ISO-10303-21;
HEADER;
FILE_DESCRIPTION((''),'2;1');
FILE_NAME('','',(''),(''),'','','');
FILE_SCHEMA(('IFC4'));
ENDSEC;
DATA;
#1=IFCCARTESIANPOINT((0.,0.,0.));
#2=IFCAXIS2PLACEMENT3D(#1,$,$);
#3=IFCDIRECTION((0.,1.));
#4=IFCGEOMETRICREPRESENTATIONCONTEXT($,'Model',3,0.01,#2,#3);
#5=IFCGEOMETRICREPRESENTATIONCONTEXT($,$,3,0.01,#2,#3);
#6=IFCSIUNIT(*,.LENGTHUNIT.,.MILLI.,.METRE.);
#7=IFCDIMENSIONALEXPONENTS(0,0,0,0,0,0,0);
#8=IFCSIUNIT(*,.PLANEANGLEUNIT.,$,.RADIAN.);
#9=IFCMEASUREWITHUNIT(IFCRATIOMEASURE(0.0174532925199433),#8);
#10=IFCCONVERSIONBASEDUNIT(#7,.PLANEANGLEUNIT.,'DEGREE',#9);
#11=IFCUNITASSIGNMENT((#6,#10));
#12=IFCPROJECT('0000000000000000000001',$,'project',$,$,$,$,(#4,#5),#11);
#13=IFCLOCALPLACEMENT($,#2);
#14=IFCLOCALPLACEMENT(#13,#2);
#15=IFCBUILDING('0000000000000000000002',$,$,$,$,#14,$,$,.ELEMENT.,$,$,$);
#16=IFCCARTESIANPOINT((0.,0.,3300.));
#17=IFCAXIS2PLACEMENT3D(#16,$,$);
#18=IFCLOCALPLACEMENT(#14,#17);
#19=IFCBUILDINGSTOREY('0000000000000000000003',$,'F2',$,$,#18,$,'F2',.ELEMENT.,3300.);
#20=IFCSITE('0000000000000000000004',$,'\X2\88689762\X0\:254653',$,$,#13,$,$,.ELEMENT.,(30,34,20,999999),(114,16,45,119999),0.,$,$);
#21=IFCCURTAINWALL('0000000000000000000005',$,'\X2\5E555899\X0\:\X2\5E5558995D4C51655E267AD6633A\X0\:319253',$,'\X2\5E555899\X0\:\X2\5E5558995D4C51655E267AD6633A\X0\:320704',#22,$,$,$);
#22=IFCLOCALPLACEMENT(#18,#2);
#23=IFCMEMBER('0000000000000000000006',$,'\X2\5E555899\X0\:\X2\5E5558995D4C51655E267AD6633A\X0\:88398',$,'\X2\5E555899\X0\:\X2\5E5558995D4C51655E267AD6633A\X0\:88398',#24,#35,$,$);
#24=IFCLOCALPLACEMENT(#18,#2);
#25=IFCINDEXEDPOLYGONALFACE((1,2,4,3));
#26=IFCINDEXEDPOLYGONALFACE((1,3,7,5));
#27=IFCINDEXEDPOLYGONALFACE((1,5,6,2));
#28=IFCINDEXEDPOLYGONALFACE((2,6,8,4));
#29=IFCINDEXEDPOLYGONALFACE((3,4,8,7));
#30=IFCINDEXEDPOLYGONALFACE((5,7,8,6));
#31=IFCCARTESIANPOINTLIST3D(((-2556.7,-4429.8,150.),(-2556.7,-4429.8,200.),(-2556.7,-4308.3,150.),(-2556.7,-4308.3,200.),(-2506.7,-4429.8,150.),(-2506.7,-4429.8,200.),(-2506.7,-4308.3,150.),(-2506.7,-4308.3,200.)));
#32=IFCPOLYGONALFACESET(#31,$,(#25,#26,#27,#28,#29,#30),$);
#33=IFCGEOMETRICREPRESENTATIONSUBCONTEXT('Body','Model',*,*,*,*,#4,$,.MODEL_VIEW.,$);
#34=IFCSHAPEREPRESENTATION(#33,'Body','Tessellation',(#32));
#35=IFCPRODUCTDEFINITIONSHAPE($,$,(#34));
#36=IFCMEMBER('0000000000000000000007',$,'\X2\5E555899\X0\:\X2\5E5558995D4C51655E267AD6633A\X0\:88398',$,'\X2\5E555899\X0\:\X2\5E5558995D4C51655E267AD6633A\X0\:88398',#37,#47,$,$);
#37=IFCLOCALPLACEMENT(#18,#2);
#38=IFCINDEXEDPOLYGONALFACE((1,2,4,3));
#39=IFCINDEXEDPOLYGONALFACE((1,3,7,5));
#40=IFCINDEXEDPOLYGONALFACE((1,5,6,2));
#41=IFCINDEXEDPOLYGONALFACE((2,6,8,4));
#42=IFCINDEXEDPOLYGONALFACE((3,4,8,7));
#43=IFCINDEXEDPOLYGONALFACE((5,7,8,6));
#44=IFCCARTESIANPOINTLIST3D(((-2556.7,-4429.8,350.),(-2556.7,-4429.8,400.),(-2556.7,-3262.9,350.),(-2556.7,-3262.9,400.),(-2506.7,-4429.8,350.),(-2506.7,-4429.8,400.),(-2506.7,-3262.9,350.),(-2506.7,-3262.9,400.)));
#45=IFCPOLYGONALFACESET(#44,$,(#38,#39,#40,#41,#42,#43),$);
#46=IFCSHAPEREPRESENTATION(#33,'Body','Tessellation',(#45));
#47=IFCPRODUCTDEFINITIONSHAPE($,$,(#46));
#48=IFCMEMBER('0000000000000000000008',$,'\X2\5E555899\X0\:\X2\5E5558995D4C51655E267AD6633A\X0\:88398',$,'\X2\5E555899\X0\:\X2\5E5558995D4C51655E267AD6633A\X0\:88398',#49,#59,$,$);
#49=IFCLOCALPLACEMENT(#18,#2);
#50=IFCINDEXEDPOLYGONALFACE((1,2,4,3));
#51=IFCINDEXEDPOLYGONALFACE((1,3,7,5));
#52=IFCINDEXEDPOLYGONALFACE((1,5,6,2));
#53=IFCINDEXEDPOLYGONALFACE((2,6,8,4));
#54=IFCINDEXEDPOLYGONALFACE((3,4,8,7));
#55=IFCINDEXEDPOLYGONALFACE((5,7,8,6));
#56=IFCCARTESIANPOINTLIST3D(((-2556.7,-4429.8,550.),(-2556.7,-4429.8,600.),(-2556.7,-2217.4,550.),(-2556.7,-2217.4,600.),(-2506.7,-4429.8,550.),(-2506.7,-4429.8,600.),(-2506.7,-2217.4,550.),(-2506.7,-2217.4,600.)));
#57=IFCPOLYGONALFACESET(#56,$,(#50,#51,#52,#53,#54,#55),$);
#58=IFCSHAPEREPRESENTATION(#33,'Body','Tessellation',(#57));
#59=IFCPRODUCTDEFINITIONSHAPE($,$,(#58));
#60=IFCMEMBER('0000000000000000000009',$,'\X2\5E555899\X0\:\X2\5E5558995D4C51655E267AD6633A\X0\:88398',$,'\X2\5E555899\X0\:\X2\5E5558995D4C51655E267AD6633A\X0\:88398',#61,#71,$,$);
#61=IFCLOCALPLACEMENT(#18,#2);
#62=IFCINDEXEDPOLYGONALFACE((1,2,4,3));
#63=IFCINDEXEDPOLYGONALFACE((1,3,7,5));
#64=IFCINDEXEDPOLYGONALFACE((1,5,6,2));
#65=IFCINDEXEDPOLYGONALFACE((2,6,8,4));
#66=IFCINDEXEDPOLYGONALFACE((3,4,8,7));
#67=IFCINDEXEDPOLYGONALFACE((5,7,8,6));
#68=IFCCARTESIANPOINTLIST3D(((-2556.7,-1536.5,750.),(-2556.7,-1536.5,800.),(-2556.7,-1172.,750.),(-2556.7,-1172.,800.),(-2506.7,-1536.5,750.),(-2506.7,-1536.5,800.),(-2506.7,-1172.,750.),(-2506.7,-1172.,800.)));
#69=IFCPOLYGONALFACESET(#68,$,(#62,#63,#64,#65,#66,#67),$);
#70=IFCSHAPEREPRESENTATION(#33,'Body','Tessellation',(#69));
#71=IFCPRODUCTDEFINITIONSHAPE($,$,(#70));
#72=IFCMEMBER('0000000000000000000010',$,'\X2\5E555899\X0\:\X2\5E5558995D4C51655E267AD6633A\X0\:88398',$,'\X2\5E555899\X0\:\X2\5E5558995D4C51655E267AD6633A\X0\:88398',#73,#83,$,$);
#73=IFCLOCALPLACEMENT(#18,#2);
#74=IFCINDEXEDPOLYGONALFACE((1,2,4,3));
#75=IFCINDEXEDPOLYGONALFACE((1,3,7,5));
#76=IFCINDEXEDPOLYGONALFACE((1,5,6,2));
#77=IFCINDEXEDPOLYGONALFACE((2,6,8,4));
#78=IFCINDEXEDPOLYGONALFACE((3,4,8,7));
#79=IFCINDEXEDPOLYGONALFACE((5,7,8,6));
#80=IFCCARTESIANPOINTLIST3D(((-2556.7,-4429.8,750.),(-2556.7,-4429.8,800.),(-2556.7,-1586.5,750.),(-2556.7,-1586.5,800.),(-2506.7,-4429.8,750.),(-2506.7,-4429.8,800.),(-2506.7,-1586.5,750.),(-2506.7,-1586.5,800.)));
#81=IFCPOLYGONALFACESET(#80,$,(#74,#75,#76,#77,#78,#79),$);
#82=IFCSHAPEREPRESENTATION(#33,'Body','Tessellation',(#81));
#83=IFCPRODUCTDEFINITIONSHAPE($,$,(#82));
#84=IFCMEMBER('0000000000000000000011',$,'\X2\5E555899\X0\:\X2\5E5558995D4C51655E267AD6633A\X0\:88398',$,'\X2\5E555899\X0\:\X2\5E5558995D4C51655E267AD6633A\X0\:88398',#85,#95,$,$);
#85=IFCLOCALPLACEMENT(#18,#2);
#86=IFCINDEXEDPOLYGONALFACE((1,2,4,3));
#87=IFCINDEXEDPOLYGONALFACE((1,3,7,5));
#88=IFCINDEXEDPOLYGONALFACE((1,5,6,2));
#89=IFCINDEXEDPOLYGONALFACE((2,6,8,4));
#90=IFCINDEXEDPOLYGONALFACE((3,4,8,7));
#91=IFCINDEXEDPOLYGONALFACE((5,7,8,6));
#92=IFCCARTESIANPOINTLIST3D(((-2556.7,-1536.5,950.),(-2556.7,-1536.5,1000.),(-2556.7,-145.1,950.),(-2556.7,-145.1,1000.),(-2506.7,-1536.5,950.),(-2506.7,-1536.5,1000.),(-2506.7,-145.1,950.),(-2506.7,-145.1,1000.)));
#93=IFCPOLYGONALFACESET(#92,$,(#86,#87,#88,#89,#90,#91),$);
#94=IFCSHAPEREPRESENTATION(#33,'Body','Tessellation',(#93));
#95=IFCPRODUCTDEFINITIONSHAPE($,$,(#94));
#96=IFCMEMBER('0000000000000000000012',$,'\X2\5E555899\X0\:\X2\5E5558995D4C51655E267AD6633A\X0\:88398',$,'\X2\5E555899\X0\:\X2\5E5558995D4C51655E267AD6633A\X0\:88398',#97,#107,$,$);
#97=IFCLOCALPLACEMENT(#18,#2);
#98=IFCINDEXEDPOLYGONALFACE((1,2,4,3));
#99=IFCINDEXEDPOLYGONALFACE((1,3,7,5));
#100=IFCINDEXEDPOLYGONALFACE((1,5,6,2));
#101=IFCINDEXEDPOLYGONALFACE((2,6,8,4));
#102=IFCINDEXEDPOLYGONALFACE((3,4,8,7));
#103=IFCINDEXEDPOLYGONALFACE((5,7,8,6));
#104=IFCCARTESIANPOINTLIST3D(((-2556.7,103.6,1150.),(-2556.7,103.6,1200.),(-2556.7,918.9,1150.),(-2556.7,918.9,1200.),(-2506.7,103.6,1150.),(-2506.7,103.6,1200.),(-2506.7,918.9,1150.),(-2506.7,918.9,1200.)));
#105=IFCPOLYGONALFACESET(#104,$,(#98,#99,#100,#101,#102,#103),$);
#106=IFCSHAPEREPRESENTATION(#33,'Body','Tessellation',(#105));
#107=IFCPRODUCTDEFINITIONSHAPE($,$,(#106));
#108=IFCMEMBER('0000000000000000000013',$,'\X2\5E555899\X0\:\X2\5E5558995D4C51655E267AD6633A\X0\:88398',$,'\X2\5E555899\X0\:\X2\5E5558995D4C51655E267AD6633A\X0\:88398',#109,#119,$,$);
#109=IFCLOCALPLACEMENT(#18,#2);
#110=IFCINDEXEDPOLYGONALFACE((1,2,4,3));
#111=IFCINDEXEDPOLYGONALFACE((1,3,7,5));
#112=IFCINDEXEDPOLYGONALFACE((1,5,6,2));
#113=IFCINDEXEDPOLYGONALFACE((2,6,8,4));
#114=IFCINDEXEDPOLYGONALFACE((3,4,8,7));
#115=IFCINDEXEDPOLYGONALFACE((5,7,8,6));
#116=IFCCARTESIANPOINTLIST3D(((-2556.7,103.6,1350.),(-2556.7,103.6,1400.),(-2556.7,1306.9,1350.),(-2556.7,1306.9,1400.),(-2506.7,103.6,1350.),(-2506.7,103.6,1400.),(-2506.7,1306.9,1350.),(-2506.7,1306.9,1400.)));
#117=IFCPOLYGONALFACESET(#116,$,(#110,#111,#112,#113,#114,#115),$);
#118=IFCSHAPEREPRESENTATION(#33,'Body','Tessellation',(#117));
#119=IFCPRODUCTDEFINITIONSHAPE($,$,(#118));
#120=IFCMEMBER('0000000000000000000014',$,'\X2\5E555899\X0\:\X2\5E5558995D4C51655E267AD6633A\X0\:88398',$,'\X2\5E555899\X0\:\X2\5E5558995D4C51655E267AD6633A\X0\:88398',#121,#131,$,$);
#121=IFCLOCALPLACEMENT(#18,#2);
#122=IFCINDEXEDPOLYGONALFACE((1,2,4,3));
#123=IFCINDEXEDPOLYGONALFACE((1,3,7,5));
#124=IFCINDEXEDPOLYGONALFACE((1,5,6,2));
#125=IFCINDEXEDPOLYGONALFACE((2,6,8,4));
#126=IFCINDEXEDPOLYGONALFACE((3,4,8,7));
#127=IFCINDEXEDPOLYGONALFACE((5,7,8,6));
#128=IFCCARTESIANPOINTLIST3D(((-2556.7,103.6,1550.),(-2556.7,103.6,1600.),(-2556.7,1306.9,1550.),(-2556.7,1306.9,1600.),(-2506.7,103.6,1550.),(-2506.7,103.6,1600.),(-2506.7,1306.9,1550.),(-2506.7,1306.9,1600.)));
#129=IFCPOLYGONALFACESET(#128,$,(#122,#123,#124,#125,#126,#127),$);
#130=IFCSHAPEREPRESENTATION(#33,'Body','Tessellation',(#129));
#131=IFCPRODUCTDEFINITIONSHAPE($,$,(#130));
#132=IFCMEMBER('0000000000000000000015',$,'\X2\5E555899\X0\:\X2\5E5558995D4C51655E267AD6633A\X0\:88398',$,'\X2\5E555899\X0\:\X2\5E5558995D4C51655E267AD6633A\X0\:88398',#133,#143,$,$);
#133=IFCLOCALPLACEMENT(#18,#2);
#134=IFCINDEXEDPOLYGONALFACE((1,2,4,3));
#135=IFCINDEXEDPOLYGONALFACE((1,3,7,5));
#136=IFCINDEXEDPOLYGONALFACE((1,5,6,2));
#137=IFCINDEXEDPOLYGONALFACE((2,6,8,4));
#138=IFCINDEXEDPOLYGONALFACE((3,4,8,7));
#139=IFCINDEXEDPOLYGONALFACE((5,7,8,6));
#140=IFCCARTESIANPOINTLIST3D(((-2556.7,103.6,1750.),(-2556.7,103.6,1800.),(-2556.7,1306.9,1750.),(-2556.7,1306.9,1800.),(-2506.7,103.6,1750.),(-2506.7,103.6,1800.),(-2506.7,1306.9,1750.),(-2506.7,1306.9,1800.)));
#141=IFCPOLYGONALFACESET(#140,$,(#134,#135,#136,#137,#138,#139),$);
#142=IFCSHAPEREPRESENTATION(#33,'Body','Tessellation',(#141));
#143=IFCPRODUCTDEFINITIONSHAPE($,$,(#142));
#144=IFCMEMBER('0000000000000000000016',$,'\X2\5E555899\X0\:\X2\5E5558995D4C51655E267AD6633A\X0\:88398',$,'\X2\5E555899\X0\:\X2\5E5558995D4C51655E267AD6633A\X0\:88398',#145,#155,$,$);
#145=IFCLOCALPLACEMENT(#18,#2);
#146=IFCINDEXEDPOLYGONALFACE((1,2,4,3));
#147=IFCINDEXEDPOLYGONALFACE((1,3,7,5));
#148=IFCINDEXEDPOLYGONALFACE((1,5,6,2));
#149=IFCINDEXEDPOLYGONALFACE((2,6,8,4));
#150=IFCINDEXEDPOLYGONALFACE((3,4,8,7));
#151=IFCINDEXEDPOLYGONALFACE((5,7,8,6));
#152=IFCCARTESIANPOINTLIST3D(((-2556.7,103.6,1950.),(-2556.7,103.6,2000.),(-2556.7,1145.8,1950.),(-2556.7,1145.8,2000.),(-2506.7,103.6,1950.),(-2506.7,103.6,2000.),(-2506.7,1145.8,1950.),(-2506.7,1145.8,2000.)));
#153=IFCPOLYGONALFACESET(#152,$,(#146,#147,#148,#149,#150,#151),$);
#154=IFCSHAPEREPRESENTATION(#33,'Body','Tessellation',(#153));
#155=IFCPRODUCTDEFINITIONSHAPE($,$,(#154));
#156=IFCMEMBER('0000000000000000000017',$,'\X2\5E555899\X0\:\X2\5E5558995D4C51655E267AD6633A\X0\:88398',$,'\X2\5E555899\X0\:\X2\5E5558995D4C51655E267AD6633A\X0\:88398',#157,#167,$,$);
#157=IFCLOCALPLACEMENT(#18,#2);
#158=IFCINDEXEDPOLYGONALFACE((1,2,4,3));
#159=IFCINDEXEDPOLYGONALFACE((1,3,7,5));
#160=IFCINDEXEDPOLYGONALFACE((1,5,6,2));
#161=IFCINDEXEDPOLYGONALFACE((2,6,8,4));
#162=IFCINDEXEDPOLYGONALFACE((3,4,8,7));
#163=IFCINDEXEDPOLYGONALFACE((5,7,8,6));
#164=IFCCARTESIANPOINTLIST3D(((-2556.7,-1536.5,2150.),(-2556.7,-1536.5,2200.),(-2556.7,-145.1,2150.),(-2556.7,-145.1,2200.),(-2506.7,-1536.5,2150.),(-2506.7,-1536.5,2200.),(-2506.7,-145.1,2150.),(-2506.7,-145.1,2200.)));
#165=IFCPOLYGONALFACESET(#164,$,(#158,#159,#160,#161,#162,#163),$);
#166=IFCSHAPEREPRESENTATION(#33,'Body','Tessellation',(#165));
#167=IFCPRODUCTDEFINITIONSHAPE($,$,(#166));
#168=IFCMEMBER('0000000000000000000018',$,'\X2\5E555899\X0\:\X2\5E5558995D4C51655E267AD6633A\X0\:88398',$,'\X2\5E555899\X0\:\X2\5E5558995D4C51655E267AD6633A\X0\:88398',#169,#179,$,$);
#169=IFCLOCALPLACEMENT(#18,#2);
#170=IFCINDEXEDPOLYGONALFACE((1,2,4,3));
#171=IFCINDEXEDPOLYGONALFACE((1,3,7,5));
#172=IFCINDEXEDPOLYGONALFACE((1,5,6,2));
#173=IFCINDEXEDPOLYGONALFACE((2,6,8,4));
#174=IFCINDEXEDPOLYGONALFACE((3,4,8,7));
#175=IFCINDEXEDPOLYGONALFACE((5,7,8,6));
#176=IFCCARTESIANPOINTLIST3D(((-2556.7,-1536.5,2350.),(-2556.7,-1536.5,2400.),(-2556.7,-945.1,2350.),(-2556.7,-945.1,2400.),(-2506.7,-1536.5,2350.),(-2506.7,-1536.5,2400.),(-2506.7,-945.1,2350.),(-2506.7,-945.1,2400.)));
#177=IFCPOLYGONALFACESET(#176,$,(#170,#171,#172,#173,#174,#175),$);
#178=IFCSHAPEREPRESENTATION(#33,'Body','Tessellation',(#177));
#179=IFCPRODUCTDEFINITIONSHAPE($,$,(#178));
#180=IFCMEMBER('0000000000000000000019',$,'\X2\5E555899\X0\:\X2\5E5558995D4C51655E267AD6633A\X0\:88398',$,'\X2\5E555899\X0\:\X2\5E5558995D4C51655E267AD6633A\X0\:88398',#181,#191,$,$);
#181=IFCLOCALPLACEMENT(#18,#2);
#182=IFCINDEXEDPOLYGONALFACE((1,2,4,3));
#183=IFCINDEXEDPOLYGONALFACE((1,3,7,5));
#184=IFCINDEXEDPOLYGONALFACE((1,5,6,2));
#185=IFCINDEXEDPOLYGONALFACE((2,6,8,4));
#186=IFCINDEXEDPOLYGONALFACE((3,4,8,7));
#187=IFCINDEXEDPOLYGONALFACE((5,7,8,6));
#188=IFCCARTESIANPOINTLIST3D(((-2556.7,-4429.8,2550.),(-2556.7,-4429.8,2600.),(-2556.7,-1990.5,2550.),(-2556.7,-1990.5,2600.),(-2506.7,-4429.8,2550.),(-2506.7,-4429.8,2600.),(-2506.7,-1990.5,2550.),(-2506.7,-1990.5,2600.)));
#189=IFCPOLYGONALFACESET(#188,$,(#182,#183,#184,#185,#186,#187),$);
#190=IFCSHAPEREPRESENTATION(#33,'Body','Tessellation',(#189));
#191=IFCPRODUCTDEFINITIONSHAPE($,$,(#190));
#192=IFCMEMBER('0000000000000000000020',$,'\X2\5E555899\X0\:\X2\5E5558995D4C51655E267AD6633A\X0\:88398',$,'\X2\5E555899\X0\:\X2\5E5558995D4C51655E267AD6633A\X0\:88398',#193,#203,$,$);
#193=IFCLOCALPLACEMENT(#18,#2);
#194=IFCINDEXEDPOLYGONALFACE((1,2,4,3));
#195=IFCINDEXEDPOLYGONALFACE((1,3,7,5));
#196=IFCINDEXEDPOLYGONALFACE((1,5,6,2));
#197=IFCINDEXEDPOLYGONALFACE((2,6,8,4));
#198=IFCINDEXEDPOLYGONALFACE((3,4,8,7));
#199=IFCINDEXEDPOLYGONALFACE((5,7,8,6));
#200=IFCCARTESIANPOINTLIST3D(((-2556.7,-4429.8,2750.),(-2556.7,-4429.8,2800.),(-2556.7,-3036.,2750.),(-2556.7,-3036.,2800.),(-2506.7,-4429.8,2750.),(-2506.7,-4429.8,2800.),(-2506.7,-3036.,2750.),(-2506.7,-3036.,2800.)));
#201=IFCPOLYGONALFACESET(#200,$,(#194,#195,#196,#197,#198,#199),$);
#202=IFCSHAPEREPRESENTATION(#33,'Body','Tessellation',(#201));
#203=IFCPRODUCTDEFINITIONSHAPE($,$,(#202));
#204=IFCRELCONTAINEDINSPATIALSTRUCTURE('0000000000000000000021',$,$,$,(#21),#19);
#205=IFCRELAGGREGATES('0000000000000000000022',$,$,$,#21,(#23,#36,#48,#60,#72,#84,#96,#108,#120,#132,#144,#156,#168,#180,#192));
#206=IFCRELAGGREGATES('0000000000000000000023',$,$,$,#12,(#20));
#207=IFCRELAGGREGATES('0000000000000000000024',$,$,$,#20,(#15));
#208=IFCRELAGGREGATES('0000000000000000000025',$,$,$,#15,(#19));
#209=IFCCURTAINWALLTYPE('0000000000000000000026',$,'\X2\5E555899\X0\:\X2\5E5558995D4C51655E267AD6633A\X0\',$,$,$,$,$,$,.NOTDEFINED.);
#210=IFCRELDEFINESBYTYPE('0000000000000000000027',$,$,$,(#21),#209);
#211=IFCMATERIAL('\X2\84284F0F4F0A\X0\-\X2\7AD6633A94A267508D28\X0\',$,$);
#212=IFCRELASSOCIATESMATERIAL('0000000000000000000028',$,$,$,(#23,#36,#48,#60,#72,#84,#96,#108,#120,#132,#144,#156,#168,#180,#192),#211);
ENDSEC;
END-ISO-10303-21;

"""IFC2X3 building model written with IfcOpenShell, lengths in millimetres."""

from ifc_helpers import new_model, entity, si_unit, converted_unit, direction, frame, frame_2d, origin, origin_2d_with_axis, place, context, subcontext, project, spatial, rectangle, extrude, material, type_object, element, aggregate, save


model = new_model("IFC2X3")

# Units and contexts
model_context = context("Model", 3, precision=0.01, world=origin(), true_north=direction((0.0, 1.0)))
context_of_model = context(None, 3, precision=0.01, world=origin(), true_north=direction((0.0, 1.0)))
body_context = subcontext(model_context, "Body", "Model", "MODEL_VIEW")
ifc_project = project(units=[si_unit("LENGTHUNIT", "METRE", prefix="MILLI"), converted_unit("PLANEANGLEUNIT", "DEGREE", entity("IfcRatioMeasure", 0.0174532925199433), si_unit("PLANEANGLEUNIT", "RADIAN"), dimensions=[0, 0, 0, 0, 0, 0, 0])], contexts=[model_context, context_of_model])

# Site, building, storey
site_placement = place(None, origin())
site = spatial("IfcSite", under=ifc_project, at=site_placement, Name="表面:254653", CompositionType="ELEMENT", RefLatitude=(30, 34, 20, 999999), RefLongitude=(114, 16, 45, 119999), RefElevation=0.0)
building_placement = place(site_placement, origin())
building = spatial("IfcBuilding", under=site, at=building_placement, CompositionType="ELEMENT")
storey_placement = place(building_placement, frame((0.0, 0.0, 3300.0)))
storey = spatial("IfcBuildingStorey", under=building, at=storey_placement, Name="F2", LongName="F2", CompositionType="ELEMENT", Elevation=3300.0)

# Curtain wall, members
curtain_wall_type = type_object("IfcCurtainWallType", Name="幕墙:幕墙嵌入带竖挺", PredefinedType="NOTDEFINED")
curtain_wall_placement = place(storey_placement, frame((0.0, 0.0, -3300.0)))
curtain_wall = element("IfcCurtainWall", 1, at=curtain_wall_placement, inside=storey, type_object=curtain_wall_type, Name="幕墙:幕墙嵌入带竖挺:319253", ObjectType="幕墙:幕墙嵌入带竖挺:320704")
ifc_material = material(Name="萨伏伊-竖挺钢材质")
member_1_placement = place(curtain_wall_placement, frame((0.0, 0.0, 3300.0)))
member_1 = element("IfcMember", 2, at=member_1_placement, material=ifc_material, Name="幕墙:幕墙嵌入带竖挺:88398", ObjectType="幕墙:幕墙嵌入带竖挺:88398", context=body_context, shape_type="SweptSolid", body=[
    extrude(rectangle(XDim=50.0, YDim=50.0, at=frame_2d((0.0, 0.0), x_axis=(1.0, 0.0))), frame((-2531.7, -4429.8, 175.0), z_axis=(0.0, 1.0, 0.0), x_axis=(0.0, 0.0, -1.0)), (0.0, 0.0, 1.0), 121.5),
])
member_2_placement = place(curtain_wall_placement, frame((0.0, 0.0, 3300.0)))
member_2 = element("IfcMember", 3, at=member_2_placement, material=ifc_material, Name="幕墙:幕墙嵌入带竖挺:88398", ObjectType="幕墙:幕墙嵌入带竖挺:88398", context=body_context, shape_type="SweptSolid", body=[
    extrude(rectangle(XDim=50.0, YDim=50.0, at=origin_2d_with_axis()), frame((-2531.7, -4429.8, 375.0), z_axis=(0.0, 1.0, 0.0), x_axis=(0.0, 0.0, -1.0)), (0.0, 0.0, 1.0), 1166.9),
])
member_3_placement = place(curtain_wall_placement, frame((0.0, 0.0, 3300.0)))
member_3 = element("IfcMember", 4, at=member_3_placement, material=ifc_material, Name="幕墙:幕墙嵌入带竖挺:88398", ObjectType="幕墙:幕墙嵌入带竖挺:88398", context=body_context, shape_type="SweptSolid", body=[
    extrude(rectangle(XDim=50.0, YDim=50.0, at=frame_2d((0.0, 0.0), x_axis=(1.0, 0.0))), frame((-2531.7, -4429.8, 575.0), z_axis=(0.0, 1.0, 0.0), x_axis=(0.0, 0.0, -1.0)), (0.0, 0.0, 1.0), 2212.4),
])
member_4_placement = place(curtain_wall_placement, frame((0.0, 0.0, 3300.0)))
member_4 = element("IfcMember", 5, at=member_4_placement, material=ifc_material, Name="幕墙:幕墙嵌入带竖挺:88398", ObjectType="幕墙:幕墙嵌入带竖挺:88398", context=body_context, shape_type="SweptSolid", body=[
    extrude(rectangle(XDim=50.0, YDim=50.0, at=frame_2d((0.0, 0.0), x_axis=(1.0, 0.0))), frame((-2531.7, -1536.5, 775.0), z_axis=(0.0, 1.0, 0.0), x_axis=(0.0, 0.0, -1.0)), (0.0, 0.0, 1.0), 364.5),
])
member_5_placement = place(curtain_wall_placement, frame((0.0, 0.0, 3300.0)))
member_5 = element("IfcMember", 6, at=member_5_placement, material=ifc_material, Name="幕墙:幕墙嵌入带竖挺:88398", ObjectType="幕墙:幕墙嵌入带竖挺:88398", context=body_context, shape_type="SweptSolid", body=[
    extrude(rectangle(XDim=50.0, YDim=50.0, at=origin_2d_with_axis()), frame((-2531.7, -4429.8, 775.0), z_axis=(0.0, 1.0, 0.0), x_axis=(0.0, 0.0, -1.0)), (0.0, 0.0, 1.0), 2843.3),
])
member_6_placement = place(curtain_wall_placement, frame((0.0, 0.0, 3300.0)))
member_6 = element("IfcMember", 7, at=member_6_placement, material=ifc_material, Name="幕墙:幕墙嵌入带竖挺:88398", ObjectType="幕墙:幕墙嵌入带竖挺:88398", context=body_context, shape_type="SweptSolid", body=[
    extrude(rectangle(XDim=50.0, YDim=50.0, at=frame_2d((0.0, 0.0), x_axis=(1.0, 0.0))), frame((-2531.7, -1536.5, 975.0), z_axis=(0.0, 1.0, 0.0), x_axis=(0.0, 0.0, -1.0)), (0.0, 0.0, 1.0), 1391.3),
])
member_7_placement = place(curtain_wall_placement, frame((0.0, 0.0, 3300.0)))
member_7 = element("IfcMember", 8, at=member_7_placement, material=ifc_material, Name="幕墙:幕墙嵌入带竖挺:88398", ObjectType="幕墙:幕墙嵌入带竖挺:88398", context=body_context, shape_type="SweptSolid", body=[
    extrude(rectangle(XDim=50.0, YDim=50.0, at=origin_2d_with_axis()), frame((-2531.7, 103.6, 1175.0), z_axis=(0.0, 1.0, 0.0), x_axis=(0.0, 0.0, -1.0)), (0.0, 0.0, 1.0), 815.4),
])
member_8_placement = place(curtain_wall_placement, frame((0.0, 0.0, 3300.0)))
member_8 = element("IfcMember", 9, at=member_8_placement, material=ifc_material, Name="幕墙:幕墙嵌入带竖挺:88398", ObjectType="幕墙:幕墙嵌入带竖挺:88398", context=body_context, shape_type="SweptSolid", body=[
    extrude(rectangle(XDim=50.0, YDim=50.0, at=origin_2d_with_axis()), frame((-2531.7, 103.6, 1375.0), z_axis=(0.0, 1.0, 0.0), x_axis=(0.0, 0.0, -1.0)), (0.0, 0.0, 1.0), 1203.3),
])
member_9_placement = place(curtain_wall_placement, frame((0.0, 0.0, 3300.0)))
member_9 = element("IfcMember", 10, at=member_9_placement, material=ifc_material, Name="幕墙:幕墙嵌入带竖挺:88398", ObjectType="幕墙:幕墙嵌入带竖挺:88398", context=body_context, shape_type="SweptSolid", body=[
    extrude(rectangle(XDim=50.0, YDim=50.0, at=origin_2d_with_axis()), frame((-2531.7, 103.6, 1575.0), z_axis=(0.0, 1.0, 0.0), x_axis=(0.0, 0.0, -1.0)), (0.0, 0.0, 1.0), 1203.3),
])
member_10_placement = place(curtain_wall_placement, frame((0.0, 0.0, 3300.0)))
member_10 = element("IfcMember", 11, at=member_10_placement, material=ifc_material, Name="幕墙:幕墙嵌入带竖挺:88398", ObjectType="幕墙:幕墙嵌入带竖挺:88398", context=body_context, shape_type="SweptSolid", body=[
    extrude(rectangle(XDim=50.0, YDim=50.0, at=origin_2d_with_axis()), frame((-2531.7, 103.6, 1775.0), z_axis=(0.0, 1.0, 0.0), x_axis=(0.0, 0.0, -1.0)), (0.0, 0.0, 1.0), 1203.3),
])
member_11_placement = place(curtain_wall_placement, frame((0.0, 0.0, 3300.0)))
member_11 = element("IfcMember", 12, at=member_11_placement, material=ifc_material, Name="幕墙:幕墙嵌入带竖挺:88398", ObjectType="幕墙:幕墙嵌入带竖挺:88398", context=body_context, shape_type="SweptSolid", body=[
    extrude(rectangle(XDim=50.0, YDim=50.0, at=origin_2d_with_axis()), frame((-2531.7, 103.6, 1975.0), z_axis=(0.0, 1.0, 0.0), x_axis=(0.0, 0.0, -1.0)), (0.0, 0.0, 1.0), 1042.2),
])
member_12_placement = place(curtain_wall_placement, frame((0.0, 0.0, 3300.0)))
member_12 = element("IfcMember", 13, at=member_12_placement, material=ifc_material, Name="幕墙:幕墙嵌入带竖挺:88398", ObjectType="幕墙:幕墙嵌入带竖挺:88398", context=body_context, shape_type="SweptSolid", body=[
    extrude(rectangle(XDim=50.0, YDim=50.0, at=frame_2d((0.0, 0.0), x_axis=(1.0, 0.0))), frame((-2531.7, -1536.5, 2175.0), z_axis=(0.0, 1.0, 0.0), x_axis=(0.0, 0.0, -1.0)), (0.0, 0.0, 1.0), 1391.3),
])
member_13_placement = place(curtain_wall_placement, frame((0.0, 0.0, 3300.0)))
member_13 = element("IfcMember", 14, at=member_13_placement, material=ifc_material, Name="幕墙:幕墙嵌入带竖挺:88398", ObjectType="幕墙:幕墙嵌入带竖挺:88398", context=body_context, shape_type="SweptSolid", body=[
    extrude(rectangle(XDim=50.0, YDim=50.0, at=origin_2d_with_axis()), frame((-2531.7, -1536.5, 2375.0), z_axis=(0.0, 1.0, 0.0), x_axis=(0.0, 0.0, -1.0)), (0.0, 0.0, 1.0), 591.4),
])
member_14_placement = place(curtain_wall_placement, frame((0.0, 0.0, 3300.0)))
member_14 = element("IfcMember", 15, at=member_14_placement, material=ifc_material, Name="幕墙:幕墙嵌入带竖挺:88398", ObjectType="幕墙:幕墙嵌入带竖挺:88398", context=body_context, shape_type="SweptSolid", body=[
    extrude(rectangle(XDim=50.0, YDim=50.0, at=origin_2d_with_axis()), frame((-2531.7, -4429.8, 2575.0), z_axis=(0.0, 1.0, 0.0), x_axis=(0.0, 0.0, -1.0)), (0.0, 0.0, 1.0), 2439.3),
])
member_15_placement = place(curtain_wall_placement, frame((0.0, 0.0, 3300.0)))
member_15 = element("IfcMember", 16, at=member_15_placement, material=ifc_material, Name="幕墙:幕墙嵌入带竖挺:88398", ObjectType="幕墙:幕墙嵌入带竖挺:88398", context=body_context, shape_type="SweptSolid", body=[
    extrude(rectangle(XDim=50.0, YDim=50.0, at=origin_2d_with_axis()), frame((-2531.7, -4429.8, 2775.0), z_axis=(0.0, 1.0, 0.0), x_axis=(0.0, 0.0, -1.0)), (0.0, 0.0, 1.0), 1393.8),
])
aggregate(curtain_wall, [member_1, member_2, member_3, member_4, member_5, member_6, member_7, member_8, member_9, member_10, member_11, member_12, member_13, member_14, member_15])

save(model, "model.ifc")
